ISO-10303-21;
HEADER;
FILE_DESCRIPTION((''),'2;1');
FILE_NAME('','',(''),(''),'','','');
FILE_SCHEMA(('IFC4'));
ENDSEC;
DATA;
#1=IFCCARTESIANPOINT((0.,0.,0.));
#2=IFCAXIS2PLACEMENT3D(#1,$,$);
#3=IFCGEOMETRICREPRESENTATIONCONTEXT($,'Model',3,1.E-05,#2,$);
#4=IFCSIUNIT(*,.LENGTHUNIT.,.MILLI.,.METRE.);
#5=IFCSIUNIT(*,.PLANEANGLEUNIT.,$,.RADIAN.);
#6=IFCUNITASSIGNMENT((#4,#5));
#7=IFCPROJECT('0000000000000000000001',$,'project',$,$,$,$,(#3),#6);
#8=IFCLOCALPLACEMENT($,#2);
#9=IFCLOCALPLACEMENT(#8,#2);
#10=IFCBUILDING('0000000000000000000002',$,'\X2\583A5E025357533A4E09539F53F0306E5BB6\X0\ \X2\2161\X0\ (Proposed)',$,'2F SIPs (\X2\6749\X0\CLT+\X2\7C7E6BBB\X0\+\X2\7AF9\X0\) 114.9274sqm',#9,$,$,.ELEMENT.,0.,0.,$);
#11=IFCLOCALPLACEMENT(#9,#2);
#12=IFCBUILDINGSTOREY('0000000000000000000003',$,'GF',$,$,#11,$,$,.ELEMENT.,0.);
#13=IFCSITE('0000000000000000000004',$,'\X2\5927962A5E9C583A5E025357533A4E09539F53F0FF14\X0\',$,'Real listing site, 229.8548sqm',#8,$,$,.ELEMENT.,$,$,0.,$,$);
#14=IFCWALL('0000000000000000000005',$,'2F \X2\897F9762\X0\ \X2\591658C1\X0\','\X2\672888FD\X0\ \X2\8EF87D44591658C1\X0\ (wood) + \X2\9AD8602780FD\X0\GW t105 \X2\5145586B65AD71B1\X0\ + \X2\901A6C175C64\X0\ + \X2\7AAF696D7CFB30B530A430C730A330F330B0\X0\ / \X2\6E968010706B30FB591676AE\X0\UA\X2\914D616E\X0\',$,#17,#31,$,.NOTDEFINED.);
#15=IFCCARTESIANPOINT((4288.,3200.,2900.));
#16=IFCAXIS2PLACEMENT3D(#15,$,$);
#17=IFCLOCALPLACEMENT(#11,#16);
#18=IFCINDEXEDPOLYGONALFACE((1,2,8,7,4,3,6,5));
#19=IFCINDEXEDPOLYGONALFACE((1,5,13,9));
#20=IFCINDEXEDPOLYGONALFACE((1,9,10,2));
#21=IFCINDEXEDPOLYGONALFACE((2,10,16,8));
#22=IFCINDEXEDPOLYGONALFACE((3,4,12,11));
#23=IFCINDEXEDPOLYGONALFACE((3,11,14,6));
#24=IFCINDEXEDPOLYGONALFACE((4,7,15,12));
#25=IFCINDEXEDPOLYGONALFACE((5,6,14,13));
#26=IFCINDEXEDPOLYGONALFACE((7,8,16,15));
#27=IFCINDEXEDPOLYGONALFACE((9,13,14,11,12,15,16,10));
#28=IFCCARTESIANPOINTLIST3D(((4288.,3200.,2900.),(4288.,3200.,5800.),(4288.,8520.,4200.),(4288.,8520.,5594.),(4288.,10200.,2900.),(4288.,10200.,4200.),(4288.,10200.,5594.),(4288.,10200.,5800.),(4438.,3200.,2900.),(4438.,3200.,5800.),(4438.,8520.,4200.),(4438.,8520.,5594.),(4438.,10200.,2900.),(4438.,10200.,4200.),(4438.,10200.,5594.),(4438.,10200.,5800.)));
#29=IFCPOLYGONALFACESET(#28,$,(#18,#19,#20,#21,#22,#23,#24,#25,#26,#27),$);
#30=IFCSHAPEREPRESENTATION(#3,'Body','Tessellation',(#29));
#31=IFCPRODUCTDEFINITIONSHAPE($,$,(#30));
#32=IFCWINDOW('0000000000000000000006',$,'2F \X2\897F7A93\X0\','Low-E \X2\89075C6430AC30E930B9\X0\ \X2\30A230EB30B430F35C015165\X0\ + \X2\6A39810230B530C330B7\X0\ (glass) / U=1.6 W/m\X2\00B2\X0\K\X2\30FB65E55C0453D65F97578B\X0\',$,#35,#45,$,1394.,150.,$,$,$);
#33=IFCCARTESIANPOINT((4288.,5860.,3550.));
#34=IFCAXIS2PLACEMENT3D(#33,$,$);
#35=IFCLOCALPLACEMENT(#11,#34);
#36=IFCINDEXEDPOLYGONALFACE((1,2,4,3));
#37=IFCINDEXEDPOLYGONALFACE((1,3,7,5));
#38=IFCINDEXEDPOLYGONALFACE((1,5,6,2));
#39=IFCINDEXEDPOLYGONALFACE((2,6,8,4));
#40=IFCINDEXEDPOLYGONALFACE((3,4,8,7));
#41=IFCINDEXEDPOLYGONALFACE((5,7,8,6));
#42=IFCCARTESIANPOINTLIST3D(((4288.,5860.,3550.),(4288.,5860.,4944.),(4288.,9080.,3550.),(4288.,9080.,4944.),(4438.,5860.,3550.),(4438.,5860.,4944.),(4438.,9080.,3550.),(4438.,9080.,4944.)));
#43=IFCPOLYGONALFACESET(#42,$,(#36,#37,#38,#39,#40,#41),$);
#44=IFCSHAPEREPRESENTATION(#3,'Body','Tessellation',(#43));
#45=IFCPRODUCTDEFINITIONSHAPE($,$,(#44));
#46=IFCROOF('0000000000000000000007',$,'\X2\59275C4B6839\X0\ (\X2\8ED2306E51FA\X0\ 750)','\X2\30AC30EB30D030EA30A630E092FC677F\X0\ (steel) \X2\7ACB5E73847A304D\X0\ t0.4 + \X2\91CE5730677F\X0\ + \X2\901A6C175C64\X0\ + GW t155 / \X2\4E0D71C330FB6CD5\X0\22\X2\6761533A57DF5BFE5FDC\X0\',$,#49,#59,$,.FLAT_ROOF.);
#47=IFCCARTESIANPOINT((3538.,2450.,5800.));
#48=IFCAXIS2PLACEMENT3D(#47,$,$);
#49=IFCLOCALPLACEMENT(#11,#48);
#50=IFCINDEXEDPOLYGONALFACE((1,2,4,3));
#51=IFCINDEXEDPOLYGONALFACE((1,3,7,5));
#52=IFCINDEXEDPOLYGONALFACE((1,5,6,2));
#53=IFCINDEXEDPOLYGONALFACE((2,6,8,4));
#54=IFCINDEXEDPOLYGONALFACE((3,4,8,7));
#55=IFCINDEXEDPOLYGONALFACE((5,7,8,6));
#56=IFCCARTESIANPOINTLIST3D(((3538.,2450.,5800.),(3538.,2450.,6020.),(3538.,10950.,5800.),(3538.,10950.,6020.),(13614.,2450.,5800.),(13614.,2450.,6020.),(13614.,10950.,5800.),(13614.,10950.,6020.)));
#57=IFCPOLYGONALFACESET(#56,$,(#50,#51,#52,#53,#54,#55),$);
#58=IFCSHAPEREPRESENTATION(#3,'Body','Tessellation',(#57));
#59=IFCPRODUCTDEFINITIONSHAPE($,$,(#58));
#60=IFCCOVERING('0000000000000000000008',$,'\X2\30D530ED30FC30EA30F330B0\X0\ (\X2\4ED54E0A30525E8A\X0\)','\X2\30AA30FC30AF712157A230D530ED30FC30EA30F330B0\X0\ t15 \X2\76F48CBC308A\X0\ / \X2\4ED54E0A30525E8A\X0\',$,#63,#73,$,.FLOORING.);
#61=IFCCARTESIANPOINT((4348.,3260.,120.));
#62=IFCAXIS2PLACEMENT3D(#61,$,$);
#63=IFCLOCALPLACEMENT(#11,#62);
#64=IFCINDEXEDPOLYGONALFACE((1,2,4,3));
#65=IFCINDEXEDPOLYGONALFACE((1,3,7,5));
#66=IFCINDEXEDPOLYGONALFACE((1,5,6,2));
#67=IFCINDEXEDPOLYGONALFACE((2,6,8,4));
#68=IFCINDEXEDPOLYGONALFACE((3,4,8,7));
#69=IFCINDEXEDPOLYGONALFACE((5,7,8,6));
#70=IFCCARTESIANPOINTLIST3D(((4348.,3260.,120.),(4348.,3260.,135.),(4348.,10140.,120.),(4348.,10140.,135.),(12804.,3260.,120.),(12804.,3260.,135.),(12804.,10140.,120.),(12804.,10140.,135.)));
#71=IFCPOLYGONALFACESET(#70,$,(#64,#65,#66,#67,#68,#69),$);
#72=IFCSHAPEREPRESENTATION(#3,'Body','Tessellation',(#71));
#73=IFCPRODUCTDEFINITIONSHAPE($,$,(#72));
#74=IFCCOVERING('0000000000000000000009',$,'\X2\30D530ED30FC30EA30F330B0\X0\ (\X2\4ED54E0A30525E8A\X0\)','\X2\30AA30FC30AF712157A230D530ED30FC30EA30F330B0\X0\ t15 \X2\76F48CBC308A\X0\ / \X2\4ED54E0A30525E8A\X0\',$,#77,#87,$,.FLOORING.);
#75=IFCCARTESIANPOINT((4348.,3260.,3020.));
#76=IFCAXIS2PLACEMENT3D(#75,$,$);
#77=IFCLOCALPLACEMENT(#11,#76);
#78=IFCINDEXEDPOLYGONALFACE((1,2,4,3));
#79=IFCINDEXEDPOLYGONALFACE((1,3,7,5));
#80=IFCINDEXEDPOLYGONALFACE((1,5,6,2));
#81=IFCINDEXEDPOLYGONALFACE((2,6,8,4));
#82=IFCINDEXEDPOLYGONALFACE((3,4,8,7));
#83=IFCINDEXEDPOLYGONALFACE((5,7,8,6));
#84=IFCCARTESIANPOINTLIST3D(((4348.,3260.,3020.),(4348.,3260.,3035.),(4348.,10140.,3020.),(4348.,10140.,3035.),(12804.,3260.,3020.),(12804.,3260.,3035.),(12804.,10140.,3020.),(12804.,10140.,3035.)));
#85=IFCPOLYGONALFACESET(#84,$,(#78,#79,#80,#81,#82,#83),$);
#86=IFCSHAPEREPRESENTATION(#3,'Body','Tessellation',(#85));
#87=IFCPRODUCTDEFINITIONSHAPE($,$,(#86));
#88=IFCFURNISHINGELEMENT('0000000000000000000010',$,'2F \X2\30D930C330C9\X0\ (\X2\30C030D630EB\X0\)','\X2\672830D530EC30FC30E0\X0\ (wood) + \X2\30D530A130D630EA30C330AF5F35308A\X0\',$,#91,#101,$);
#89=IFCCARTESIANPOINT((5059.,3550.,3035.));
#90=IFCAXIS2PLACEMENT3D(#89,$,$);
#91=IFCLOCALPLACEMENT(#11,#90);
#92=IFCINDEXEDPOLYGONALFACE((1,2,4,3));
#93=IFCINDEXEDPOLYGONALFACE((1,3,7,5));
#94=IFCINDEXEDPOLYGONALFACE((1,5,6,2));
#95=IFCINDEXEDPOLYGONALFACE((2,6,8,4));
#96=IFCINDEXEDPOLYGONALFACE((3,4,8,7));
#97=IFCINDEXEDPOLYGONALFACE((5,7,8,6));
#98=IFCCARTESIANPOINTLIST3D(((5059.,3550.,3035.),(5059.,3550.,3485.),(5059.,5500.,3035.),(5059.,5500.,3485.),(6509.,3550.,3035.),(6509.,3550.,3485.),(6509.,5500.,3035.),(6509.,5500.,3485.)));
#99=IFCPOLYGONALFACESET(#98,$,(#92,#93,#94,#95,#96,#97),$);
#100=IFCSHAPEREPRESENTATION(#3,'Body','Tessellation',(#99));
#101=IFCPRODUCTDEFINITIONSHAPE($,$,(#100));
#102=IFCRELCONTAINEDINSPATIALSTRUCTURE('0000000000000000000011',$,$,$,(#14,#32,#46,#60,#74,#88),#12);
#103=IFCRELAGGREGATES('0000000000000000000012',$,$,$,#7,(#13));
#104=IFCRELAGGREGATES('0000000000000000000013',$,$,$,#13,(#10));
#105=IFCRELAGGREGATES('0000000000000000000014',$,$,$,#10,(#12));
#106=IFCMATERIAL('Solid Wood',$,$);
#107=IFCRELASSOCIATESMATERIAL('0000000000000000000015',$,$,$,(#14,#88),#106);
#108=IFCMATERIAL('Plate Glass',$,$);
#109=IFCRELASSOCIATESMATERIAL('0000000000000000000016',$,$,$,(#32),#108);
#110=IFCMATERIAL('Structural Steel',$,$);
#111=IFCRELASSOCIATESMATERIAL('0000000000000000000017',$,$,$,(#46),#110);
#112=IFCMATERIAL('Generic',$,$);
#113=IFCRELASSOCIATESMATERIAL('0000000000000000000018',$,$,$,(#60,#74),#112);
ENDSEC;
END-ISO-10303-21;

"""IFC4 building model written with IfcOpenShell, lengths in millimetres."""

from ifc_helpers import new_model, si_unit, frame, frame_2d, origin, place, context, project, spatial, rectangle, extrude, material, element, fill, save


model = new_model("IFC4")

# Units and contexts
model_context = context("Model", 3, precision=1e-05, world=origin())
ifc_project = project(units=[si_unit("LENGTHUNIT", "METRE", prefix="MILLI"), si_unit("PLANEANGLEUNIT", "RADIAN")], contexts=[model_context])

# Site, building, storey
site_placement = place(None, origin())
site = spatial("IfcSite", under=ifc_project, at=site_placement, Name="大阪府堺市南区三原台４", ObjectType="Real listing site, 229.8548sqm", CompositionType="ELEMENT", RefElevation=0.0)
building_placement = place(site_placement, origin())
building = spatial("IfcBuilding", under=site, at=building_placement, Name="堺市南区三原台の家 Ⅱ (Proposed)", ObjectType="2F SIPs (杉CLT+籾殻+竹) 114.9274sqm", CompositionType="ELEMENT", ElevationOfRefHeight=0.0, ElevationOfTerrain=0.0)
storey_placement = place(building_placement, origin())
storey = spatial("IfcBuildingStorey", under=building, at=storey_placement, Name="GF", CompositionType="ELEMENT", Elevation=0.0)

# Shared definitions
ifc_material_1 = material(Name="Solid Wood")

# Shared definitions
ifc_material_2 = material(Name="Plate Glass")

# Wall, opening, window
wall_1_placement = place(storey_placement, frame((4288.0, 3200.0, 2900.0)))
wall_1 = element("IfcWall", 1, at=wall_1_placement, inside=storey, material=ifc_material_1, Name="2F 西面 外壁", Description="木製 軸組外壁 (wood) + 高性能GW t105 充填断熱 + 通気層 + 窯業系サイディング / 準耐火・外皮UA配慮", PredefinedType="NOTDEFINED", context=model_context, shape_type="SweptSolid", body=[
    extrude(rectangle(XDim=150.0, YDim=7000.0, at=frame_2d((75.0, 3500.0))), frame((4288.0, 3200.0, 2900.0)), (0.0, 0.0, 1.0), 2900.0),
])
opening_1_placement = place(storey_placement, frame((4288.0, 5860.0, 3550.0)))
opening_1 = element("IfcOpeningElement", 2, at=opening_1_placement, cuts=wall_1, PredefinedType="NOTDEFINED", context=model_context, shape_type="SweptSolid", body=[
    extrude(rectangle(XDim=150.0, YDim=3220.0, at=frame_2d((75.0, 1610.0))), frame((4288.0, 5860.0, 3550.0)), (0.0, 0.0, 1.0), 1394.0),
])
window_1_placement = place(storey_placement, frame((4288.0, 5860.0, 3550.0)))
window_1 = element("IfcWindow", 3, at=window_1_placement, inside=storey, material=ifc_material_2, Name="2F 西窓", Description="Low-E 複層ガラス アルゴン封入 + 樹脂サッシ (glass) / U=1.6 W/m²K・日射取得型", OverallHeight=1394.0, OverallWidth=150.0, context=model_context, shape_type="SweptSolid", body=[
    extrude(rectangle(XDim=150.0, YDim=3220.0, at=frame_2d((75.0, 1610.0))), frame((4288.0, 5860.0, 3550.0)), (0.0, 0.0, 1.0), 1394.0),
])
fill(opening_1, window_1)

# Roof
ifc_material_3 = material(Name="Structural Steel")
roof_placement = place(storey_placement, frame((3538.0, 2450.0, 5800.0)))
element("IfcRoof", 4, at=roof_placement, inside=storey, material=ifc_material_3, Name="大屋根 (軒の出 750)", Description="ガルバリウム鋼板 (steel) 立平葺き t0.4 + 野地板 + 通気層 + GW t155 / 不燃・法22条区域対応", PredefinedType="FLAT_ROOF", context=model_context, shape_type="SweptSolid", body=[
    extrude(rectangle(XDim=10076.0, YDim=8500.0, at=frame_2d((5038.0, 4250.0))), frame((3538.0, 2450.0, 5800.0)), (0.0, 0.0, 1.0), 220.0),
])

# Coverings
ifc_material_4 = material(Name="Generic")
covering_1_placement = place(storey_placement, frame((4348.0, 3260.0, 120.0)))
element("IfcCovering", 5, at=covering_1_placement, inside=storey, material=ifc_material_4, Name="フローリング (仕上げ床)", Description="オーク無垢フローリング t15 直貼り / 仕上げ床", PredefinedType="FLOORING", context=model_context, shape_type="SweptSolid", body=[
    extrude(rectangle(XDim=8456.0, YDim=6880.0, at=frame_2d((4228.0, 3440.0))), frame((4348.0, 3260.0, 120.0)), (0.0, 0.0, 1.0), 15.0),
])
covering_2_placement = place(storey_placement, frame((4348.0, 3260.0, 3020.0)))
element("IfcCovering", 6, at=covering_2_placement, inside=storey, material=ifc_material_4, Name="フローリング (仕上げ床)", Description="オーク無垢フローリング t15 直貼り / 仕上げ床", PredefinedType="FLOORING", context=model_context, shape_type="SweptSolid", body=[
    extrude(rectangle(XDim=8456.0, YDim=6880.0, at=frame_2d((4228.0, 3440.0))), frame((4348.0, 3260.0, 3020.0)), (0.0, 0.0, 1.0), 15.0),
])

# Furnishing element
furnishing_placement = place(storey_placement, frame((5059.0, 3550.0, 3035.0)))
element("IfcFurnishingElement", 7, at=furnishing_placement, inside=storey, material=ifc_material_1, Name="2F ベッド (ダブル)", Description="木フレーム (wood) + ファブリック張り", context=model_context, shape_type="SweptSolid", body=[
    extrude(rectangle(XDim=1450.0, YDim=1950.0, at=frame_2d((725.0, 975.0))), frame((5059.0, 3550.0, 3035.0)), (0.0, 0.0, 1.0), 450.0),
])

save(model, "model.ifc")
